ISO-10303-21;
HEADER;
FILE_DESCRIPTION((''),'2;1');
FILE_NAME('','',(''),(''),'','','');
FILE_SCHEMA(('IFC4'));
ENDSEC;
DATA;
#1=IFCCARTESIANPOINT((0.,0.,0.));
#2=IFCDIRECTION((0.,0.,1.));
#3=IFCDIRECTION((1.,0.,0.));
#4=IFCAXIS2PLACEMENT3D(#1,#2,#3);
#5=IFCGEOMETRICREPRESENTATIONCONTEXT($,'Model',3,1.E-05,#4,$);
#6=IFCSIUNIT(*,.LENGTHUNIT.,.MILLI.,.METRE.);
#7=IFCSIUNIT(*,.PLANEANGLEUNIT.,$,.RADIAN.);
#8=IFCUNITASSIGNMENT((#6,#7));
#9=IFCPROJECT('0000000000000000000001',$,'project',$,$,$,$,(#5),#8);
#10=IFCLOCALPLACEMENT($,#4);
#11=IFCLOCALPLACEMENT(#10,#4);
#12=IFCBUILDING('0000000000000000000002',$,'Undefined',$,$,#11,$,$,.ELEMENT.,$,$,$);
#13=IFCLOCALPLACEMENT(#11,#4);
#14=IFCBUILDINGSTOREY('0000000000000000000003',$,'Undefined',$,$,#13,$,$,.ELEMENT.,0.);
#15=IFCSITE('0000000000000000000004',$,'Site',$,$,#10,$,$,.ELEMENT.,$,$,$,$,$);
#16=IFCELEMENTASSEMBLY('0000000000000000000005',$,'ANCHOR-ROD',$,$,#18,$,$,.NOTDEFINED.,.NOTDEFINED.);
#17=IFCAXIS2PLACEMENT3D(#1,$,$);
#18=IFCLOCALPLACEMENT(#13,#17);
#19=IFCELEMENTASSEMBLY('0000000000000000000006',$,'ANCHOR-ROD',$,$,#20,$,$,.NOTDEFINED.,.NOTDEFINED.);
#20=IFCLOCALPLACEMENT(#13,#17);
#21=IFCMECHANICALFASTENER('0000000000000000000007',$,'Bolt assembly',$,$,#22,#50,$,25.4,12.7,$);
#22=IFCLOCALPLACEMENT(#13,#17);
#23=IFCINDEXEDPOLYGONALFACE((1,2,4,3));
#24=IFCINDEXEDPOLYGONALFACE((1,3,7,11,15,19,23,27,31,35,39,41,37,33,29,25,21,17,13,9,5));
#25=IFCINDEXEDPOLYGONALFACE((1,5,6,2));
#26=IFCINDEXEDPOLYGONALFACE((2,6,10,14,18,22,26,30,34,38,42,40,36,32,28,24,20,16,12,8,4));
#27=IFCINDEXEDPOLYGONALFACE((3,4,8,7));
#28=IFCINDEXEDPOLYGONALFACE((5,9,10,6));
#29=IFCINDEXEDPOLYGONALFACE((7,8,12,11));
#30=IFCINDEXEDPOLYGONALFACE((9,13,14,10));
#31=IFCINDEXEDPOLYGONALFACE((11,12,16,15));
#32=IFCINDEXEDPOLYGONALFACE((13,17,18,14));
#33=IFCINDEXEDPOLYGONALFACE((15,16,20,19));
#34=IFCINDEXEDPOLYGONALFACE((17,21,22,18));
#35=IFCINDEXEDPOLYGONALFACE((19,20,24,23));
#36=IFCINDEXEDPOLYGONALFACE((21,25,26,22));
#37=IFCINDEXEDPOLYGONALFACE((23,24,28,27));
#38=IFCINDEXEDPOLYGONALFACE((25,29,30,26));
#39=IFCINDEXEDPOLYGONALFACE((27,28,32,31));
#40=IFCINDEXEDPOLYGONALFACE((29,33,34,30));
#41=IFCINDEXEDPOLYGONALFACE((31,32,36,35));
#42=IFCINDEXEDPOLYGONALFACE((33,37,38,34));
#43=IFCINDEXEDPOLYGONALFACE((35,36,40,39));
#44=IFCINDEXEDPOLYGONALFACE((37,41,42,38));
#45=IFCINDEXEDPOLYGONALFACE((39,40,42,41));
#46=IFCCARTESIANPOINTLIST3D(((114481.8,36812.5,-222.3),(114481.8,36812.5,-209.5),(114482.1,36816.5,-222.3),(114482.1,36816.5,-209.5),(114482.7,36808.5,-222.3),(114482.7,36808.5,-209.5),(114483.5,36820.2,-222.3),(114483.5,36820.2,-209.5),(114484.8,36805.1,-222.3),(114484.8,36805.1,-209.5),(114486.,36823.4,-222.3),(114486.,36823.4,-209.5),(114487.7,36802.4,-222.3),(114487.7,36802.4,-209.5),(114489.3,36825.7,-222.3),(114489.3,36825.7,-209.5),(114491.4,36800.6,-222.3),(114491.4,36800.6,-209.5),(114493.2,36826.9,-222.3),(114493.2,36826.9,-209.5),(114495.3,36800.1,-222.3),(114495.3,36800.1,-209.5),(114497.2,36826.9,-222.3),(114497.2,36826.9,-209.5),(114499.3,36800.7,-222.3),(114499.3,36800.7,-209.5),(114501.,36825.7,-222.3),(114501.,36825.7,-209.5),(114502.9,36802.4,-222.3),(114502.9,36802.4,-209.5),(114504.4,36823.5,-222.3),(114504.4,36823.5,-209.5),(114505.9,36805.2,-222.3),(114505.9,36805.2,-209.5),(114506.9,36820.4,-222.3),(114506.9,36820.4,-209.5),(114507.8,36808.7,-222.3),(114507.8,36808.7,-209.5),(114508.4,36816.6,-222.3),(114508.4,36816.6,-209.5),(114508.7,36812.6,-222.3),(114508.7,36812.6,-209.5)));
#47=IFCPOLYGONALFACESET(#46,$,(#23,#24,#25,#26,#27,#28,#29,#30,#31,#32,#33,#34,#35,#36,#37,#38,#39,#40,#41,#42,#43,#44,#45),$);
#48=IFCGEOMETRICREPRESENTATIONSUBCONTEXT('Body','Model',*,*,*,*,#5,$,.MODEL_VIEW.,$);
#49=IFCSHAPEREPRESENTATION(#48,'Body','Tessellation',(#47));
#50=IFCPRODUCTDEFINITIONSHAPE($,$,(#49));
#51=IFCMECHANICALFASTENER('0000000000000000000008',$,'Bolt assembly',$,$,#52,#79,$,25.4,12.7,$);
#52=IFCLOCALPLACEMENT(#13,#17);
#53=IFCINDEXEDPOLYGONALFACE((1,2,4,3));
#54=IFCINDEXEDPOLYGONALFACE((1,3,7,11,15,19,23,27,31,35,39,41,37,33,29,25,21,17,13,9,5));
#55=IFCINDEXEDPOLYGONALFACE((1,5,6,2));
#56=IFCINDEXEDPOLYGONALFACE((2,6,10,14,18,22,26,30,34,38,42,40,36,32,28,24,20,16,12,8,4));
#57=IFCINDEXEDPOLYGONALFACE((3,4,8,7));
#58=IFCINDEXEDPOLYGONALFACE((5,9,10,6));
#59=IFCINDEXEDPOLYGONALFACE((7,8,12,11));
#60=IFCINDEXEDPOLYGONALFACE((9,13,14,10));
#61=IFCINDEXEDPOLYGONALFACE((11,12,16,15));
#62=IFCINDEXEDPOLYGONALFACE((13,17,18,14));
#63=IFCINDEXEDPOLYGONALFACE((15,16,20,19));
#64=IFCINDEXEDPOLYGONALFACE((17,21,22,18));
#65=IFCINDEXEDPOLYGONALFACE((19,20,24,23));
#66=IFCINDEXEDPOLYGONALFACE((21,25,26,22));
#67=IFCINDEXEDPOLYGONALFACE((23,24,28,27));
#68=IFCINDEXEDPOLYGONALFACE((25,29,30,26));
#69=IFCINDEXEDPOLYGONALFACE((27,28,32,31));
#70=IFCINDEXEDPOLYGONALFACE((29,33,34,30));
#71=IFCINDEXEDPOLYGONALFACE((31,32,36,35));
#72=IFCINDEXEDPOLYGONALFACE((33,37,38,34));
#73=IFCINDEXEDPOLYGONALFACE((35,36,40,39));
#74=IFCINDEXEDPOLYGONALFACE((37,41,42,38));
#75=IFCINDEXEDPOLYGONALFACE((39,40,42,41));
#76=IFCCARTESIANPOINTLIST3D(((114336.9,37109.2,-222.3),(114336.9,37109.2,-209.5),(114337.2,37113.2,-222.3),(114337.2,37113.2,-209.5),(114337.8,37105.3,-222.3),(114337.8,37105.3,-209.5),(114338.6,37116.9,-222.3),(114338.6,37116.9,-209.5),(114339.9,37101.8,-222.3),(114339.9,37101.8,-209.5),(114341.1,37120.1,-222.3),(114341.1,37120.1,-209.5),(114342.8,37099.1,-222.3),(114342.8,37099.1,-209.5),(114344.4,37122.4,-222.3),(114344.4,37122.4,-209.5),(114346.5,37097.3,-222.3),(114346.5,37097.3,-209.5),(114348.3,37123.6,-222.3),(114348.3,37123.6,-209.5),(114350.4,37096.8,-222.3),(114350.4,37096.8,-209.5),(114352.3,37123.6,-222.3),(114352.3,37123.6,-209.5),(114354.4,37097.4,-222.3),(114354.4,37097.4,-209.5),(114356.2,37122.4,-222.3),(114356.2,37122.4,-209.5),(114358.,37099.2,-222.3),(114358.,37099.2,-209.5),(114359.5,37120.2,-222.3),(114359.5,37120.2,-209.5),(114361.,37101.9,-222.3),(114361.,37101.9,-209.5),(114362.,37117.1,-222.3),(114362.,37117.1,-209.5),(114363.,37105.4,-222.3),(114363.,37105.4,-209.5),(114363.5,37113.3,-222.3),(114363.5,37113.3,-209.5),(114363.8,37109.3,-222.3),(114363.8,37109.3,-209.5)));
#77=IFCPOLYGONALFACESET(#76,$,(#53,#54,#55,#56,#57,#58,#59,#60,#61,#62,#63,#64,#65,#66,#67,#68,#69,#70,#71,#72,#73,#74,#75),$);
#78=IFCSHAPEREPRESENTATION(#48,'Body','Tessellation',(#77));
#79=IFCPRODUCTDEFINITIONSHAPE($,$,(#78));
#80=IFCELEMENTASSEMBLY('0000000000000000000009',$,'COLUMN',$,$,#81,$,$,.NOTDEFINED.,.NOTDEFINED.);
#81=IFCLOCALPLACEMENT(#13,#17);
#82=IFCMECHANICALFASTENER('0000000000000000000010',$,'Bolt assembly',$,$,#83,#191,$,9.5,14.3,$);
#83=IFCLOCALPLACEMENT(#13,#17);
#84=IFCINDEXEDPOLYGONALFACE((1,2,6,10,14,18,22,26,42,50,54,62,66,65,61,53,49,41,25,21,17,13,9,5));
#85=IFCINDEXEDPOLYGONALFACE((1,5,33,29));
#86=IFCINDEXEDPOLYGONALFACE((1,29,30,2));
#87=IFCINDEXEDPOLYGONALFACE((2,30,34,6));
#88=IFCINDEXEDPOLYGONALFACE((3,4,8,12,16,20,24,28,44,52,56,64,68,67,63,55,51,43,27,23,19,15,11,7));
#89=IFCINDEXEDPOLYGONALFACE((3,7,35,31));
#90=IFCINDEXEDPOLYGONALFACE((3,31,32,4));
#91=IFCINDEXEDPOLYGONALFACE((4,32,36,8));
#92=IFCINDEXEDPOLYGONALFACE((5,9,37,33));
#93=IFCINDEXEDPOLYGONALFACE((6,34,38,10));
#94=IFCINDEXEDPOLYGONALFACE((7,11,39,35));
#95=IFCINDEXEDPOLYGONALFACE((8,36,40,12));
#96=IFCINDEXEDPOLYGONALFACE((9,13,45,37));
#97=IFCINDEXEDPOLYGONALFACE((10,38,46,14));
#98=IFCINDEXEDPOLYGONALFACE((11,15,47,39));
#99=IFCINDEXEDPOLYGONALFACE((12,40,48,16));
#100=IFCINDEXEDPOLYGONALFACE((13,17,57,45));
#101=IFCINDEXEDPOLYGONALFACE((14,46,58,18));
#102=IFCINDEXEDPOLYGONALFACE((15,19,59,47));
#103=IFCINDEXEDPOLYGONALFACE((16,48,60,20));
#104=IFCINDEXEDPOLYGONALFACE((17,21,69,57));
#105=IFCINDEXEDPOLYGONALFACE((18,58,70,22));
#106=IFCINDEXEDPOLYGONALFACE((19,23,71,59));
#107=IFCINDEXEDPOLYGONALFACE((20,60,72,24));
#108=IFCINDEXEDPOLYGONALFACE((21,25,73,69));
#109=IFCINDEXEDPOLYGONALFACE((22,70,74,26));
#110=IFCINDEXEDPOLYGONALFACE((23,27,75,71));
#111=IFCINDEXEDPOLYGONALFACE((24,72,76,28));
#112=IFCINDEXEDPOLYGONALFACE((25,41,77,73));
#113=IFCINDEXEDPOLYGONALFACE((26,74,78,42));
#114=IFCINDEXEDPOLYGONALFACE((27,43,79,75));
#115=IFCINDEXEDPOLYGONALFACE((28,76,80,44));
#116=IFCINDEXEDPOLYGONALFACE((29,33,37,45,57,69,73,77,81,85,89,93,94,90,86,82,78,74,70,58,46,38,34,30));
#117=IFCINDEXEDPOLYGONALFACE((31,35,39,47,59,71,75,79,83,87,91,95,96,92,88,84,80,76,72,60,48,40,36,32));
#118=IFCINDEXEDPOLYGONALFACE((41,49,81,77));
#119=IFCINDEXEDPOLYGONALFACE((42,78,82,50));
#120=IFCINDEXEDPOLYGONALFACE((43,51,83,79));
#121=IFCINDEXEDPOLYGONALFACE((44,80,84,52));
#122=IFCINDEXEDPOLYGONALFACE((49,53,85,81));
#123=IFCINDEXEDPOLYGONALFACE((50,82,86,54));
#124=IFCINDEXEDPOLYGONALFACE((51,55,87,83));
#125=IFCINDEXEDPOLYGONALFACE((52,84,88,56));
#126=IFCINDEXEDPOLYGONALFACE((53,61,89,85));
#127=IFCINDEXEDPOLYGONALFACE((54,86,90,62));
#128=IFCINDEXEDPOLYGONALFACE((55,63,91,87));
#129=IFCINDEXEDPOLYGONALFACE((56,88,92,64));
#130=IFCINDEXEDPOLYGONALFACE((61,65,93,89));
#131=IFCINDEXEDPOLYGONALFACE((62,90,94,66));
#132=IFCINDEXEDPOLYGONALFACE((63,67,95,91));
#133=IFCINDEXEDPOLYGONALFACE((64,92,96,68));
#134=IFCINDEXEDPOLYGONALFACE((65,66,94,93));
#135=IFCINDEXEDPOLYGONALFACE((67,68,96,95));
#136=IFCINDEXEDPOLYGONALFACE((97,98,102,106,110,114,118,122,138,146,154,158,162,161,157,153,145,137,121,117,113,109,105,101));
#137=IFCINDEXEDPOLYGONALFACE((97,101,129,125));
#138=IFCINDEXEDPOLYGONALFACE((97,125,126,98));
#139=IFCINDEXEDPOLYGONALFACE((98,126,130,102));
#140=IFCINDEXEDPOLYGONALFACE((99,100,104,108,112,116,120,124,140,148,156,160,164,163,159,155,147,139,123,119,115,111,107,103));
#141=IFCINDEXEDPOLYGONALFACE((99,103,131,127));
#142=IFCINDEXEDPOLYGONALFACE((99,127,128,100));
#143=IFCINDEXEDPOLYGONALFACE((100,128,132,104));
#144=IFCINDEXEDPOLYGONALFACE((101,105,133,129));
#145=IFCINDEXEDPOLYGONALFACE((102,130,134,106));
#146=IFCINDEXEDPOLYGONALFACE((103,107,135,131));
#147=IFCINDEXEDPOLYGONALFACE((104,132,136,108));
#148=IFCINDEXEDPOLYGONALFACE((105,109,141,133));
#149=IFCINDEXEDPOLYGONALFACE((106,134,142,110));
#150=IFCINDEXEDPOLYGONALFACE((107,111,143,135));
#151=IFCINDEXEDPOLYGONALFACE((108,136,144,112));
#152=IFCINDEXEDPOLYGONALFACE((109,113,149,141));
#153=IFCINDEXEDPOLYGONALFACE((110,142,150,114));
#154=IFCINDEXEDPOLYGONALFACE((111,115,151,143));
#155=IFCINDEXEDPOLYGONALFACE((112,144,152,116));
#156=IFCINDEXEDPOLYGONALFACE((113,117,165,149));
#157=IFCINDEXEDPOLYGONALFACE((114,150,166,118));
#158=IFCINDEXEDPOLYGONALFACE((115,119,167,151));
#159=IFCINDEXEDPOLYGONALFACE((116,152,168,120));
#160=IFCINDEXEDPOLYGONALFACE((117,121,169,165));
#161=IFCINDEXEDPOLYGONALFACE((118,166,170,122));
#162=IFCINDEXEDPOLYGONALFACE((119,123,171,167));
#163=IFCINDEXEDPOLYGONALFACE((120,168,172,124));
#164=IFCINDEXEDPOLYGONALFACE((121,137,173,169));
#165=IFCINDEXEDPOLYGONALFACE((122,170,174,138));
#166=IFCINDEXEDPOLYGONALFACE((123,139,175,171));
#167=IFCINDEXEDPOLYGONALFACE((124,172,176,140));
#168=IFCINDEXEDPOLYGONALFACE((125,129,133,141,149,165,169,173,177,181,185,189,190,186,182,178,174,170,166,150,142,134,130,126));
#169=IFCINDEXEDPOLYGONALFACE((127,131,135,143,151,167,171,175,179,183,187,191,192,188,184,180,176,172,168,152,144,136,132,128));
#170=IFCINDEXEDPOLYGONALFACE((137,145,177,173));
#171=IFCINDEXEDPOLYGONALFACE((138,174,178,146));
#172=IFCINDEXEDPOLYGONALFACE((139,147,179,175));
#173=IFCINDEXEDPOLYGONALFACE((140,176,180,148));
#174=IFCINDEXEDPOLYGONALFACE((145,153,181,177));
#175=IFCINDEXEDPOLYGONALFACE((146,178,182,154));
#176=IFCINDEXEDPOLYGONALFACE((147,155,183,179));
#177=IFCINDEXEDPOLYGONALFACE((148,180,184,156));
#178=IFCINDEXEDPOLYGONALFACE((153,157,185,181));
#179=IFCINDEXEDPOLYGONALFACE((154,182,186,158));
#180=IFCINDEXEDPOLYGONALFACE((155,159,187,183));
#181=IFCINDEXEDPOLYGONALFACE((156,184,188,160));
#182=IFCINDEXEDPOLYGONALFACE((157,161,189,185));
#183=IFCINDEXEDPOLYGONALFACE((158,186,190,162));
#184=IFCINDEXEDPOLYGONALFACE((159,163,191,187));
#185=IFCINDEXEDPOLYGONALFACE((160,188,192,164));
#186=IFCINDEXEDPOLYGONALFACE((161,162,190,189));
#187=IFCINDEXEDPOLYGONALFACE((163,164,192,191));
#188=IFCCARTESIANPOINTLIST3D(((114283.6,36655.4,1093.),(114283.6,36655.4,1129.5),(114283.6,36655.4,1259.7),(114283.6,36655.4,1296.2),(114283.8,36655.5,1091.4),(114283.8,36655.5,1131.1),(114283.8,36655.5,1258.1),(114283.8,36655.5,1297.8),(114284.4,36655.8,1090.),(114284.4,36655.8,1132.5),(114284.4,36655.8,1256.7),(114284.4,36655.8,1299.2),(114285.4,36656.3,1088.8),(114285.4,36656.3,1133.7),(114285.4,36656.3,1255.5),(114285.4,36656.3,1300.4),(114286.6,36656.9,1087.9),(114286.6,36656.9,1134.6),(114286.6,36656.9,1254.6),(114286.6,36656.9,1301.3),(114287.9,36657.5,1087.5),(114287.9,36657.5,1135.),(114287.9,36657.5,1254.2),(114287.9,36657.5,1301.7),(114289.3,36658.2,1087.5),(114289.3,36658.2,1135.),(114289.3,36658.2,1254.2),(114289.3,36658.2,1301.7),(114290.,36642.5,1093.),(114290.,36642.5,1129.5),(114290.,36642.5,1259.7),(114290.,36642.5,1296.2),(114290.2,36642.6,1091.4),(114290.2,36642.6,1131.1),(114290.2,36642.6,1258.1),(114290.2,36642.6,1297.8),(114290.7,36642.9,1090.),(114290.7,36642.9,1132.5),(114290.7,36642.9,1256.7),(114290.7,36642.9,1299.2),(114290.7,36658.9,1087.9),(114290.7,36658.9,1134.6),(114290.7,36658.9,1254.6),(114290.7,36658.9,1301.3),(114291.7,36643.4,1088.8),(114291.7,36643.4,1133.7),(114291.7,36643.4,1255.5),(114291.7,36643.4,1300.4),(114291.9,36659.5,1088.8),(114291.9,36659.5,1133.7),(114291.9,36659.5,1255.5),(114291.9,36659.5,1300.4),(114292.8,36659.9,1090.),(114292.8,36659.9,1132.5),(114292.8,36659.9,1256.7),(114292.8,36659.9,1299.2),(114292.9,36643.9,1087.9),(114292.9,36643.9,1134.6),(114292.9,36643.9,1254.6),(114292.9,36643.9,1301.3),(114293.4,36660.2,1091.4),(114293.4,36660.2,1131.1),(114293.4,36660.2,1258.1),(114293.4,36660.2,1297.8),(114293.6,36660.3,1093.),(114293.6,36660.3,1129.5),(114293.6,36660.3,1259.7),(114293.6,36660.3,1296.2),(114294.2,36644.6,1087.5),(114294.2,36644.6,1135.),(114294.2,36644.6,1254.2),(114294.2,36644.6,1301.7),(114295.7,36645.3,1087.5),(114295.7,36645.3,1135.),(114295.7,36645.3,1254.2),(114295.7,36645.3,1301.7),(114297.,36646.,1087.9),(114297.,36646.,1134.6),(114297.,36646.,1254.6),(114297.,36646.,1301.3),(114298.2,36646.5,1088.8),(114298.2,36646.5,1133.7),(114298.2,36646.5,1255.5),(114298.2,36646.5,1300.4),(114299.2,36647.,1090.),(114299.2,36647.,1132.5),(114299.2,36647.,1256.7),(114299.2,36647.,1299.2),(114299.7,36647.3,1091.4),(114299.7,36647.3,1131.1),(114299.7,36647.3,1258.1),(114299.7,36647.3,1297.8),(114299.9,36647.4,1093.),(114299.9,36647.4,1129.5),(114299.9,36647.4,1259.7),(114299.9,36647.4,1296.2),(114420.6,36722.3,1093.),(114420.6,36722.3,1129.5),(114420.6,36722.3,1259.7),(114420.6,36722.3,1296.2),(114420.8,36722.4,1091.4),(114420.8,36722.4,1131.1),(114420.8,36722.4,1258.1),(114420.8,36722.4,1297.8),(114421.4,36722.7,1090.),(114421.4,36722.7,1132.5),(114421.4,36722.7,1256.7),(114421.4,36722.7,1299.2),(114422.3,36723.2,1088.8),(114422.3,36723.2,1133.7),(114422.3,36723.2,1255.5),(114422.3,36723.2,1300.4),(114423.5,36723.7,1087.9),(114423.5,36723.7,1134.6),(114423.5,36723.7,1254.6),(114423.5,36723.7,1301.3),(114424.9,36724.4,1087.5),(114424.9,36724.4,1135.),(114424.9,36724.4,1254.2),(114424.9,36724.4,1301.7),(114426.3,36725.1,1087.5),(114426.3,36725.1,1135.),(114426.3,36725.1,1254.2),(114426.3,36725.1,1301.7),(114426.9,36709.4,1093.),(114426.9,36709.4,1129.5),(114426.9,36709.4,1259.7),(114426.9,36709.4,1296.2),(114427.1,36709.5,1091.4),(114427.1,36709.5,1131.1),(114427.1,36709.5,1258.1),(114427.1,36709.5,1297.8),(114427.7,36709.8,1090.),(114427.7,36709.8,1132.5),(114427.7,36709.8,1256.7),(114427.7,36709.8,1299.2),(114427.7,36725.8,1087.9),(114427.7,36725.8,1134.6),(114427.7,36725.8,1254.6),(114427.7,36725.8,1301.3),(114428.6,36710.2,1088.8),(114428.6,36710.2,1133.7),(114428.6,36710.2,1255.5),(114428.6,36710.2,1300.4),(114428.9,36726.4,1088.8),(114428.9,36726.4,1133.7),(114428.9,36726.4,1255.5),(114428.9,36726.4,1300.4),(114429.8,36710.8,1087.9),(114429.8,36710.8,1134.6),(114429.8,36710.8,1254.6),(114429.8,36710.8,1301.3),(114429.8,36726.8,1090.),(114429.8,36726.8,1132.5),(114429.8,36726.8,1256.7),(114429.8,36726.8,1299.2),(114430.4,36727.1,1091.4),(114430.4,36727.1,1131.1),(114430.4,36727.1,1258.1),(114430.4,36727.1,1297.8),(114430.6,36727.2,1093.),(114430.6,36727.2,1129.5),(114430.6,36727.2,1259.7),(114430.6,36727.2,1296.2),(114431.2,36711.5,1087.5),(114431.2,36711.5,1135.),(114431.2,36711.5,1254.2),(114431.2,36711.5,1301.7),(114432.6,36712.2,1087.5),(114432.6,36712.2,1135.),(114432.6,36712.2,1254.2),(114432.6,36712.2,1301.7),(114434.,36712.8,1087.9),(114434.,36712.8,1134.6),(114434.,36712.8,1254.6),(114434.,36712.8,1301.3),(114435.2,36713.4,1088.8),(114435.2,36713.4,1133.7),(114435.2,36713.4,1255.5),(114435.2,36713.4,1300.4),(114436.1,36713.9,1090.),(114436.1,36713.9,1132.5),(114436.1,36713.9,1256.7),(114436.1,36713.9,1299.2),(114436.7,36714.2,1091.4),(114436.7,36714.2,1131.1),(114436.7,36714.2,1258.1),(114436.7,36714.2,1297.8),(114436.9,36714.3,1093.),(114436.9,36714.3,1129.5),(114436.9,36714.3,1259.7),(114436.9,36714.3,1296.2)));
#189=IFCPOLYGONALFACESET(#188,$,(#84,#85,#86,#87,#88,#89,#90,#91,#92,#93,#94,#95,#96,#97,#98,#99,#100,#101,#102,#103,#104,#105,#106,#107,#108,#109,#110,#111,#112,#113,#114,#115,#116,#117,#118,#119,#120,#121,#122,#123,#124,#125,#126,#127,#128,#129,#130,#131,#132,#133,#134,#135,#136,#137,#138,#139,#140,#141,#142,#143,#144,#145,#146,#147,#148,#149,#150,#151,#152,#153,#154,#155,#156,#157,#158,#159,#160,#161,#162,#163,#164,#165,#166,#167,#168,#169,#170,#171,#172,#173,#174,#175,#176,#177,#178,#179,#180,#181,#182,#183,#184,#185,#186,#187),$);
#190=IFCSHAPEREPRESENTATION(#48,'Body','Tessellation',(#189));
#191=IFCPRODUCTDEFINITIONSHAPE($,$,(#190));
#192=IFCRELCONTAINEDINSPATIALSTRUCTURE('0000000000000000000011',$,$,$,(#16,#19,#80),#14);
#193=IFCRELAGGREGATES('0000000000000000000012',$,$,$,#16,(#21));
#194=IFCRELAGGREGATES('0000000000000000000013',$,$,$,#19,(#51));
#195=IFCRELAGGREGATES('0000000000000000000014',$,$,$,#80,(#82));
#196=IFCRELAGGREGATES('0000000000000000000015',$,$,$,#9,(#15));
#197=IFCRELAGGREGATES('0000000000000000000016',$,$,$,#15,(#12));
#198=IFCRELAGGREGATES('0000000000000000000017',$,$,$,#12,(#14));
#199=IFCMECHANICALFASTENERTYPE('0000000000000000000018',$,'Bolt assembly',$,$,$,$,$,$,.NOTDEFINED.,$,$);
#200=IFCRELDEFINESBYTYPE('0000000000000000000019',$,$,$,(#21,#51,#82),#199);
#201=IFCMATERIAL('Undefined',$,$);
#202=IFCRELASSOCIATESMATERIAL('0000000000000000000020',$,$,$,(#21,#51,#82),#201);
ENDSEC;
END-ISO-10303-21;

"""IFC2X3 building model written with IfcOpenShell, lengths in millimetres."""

from ifc_helpers import new_model, si_unit, frame, frame_2d, origin_with_axes, origin_2d_with_axis, place, context, subcontext, project, spatial, polyline, circle_curve, parameter, trimmed, segment, composite_curve, circle, outline, extrude, source, transform, mapped, material, type_object, element, aggregate, save


model = new_model("IFC2X3")

# Units and contexts
model_context = context("Model", 3, precision=1e-05, world=origin_with_axes())
body_context = subcontext(model_context, "Body", "Model", "MODEL_VIEW")
ifc_project = project(units=[si_unit("LENGTHUNIT", "METRE", prefix="MILLI"), si_unit("PLANEANGLEUNIT", "RADIAN")], contexts=[model_context])

# Site, building, storey
site_placement = place(None, origin_with_axes())
site = spatial("IfcSite", under=ifc_project, at=site_placement, Name="Site", CompositionType="ELEMENT")
building_placement = place(site_placement, origin_with_axes())
building = spatial("IfcBuilding", under=site, at=building_placement, Name="Undefined", CompositionType="ELEMENT")
storey_placement = place(building_placement, origin_with_axes())
storey = spatial("IfcBuildingStorey", under=building, at=storey_placement, Name="Undefined", CompositionType="ELEMENT", Elevation=0.0)

# Element assemblies
assembly_1_placement = place(storey_placement, origin_with_axes())
assembly_1 = element("IfcElementAssembly", 1, at=assembly_1_placement, inside=storey, Name="ANCHOR-ROD", AssemblyPlace="NOTDEFINED", PredefinedType="NOTDEFINED")
assembly_2_placement = place(storey_placement, origin_with_axes())
assembly_2 = element("IfcElementAssembly", 2, at=assembly_2_placement, inside=storey, Name="ANCHOR-ROD", AssemblyPlace="NOTDEFINED", PredefinedType="NOTDEFINED")

# Mechanical fasteners
ifc_material_1 = material(Name="Undefined")
mechanical_fastener_type = type_object("IfcMechanicalFastenerType", Name="Bolt assembly")
shared_shape_1 = source(origin_with_axes(), body_context, "Body", "SweptSolid", [
    extrude(circle(Radius=13.5, at=origin_2d_with_axis()), frame((0.0, 0.0, 0.0), z_axis=(0.0, 1.0, 0.0), x_axis=(1.0, 0.0, 0.0)), (0.0, 0.0, 1.0), 12.8),
])
mechanical_fastener_1_placement = place(assembly_1_placement, frame((114495.3, 36813.5, -222.3), z_axis=(0.898581, 0.438807, 0.0), x_axis=(-0.438807, 0.898581, 0.0)))
mechanical_fastener_1 = element("IfcMechanicalFastener", 3, at=mechanical_fastener_1_placement, type_object=mechanical_fastener_type, material=ifc_material_1, Name="Bolt assembly", NominalDiameter=25.4, NominalLength=12.7, context=body_context, shape_type="MappedRepresentation", body=[
    mapped(shared_shape_1, transform((0.0, 0.0, 0.0))),
])
aggregate(assembly_1, [mechanical_fastener_1])
mechanical_fastener_2_placement = place(assembly_2_placement, frame((114350.4, 37110.3, -222.3), z_axis=(0.898581, 0.438807, 0.0), x_axis=(-0.438807, 0.898581, 0.0)))
mechanical_fastener_2 = element("IfcMechanicalFastener", 4, at=mechanical_fastener_2_placement, type_object=mechanical_fastener_type, material=ifc_material_1, Name="Bolt assembly", NominalDiameter=25.4, NominalLength=12.7, context=body_context, shape_type="MappedRepresentation", body=[
    mapped(shared_shape_1, transform((0.0, 0.0, 0.0))),
])
aggregate(assembly_2, [mechanical_fastener_2])

# Element assembly, mechanical fastener
assembly_3_placement = place(storey_placement, origin_with_axes())
assembly_3 = element("IfcElementAssembly", 5, at=assembly_3_placement, inside=storey, Name="COLUMN", AssemblyPlace="NOTDEFINED", PredefinedType="NOTDEFINED")
shared_shape_2 = source(origin_with_axes(), body_context, "Body", "SweptSolid", [
    extrude(outline(composite_curve([segment(polyline([(-18.3, 5.6), (18.3, 5.6)]), True, "CONTINUOUS"), segment(trimmed(circle_curve(frame_2d((18.3, 0.0), x_axis=(0.0, 1.0)), 5.6), [parameter(0.0)], [parameter(3.141593)], False, "PARAMETER"), True, "CONTINUOUS"), segment(polyline([(18.3, -5.6), (-18.3, -5.6)]), True, "CONTINUOUS"), segment(trimmed(circle_curve(frame_2d((-18.3, 0.0), x_axis=(0.0, -1.0)), 5.6), [parameter(0.0)], [parameter(3.141593)], False, "PARAMETER"), True, "DISCONTINUOUS")], self_intersect=False)), frame((0.0, -12.7, 0.0), z_axis=(0.0, 1.0, 0.0), x_axis=(1.0, 0.0, 0.0)), (0.0, 0.0, 1.0), 14.4),
])
mechanical_fastener_3_placement = place(assembly_3_placement, frame((114362.7, 36679.9, 1111.3), z_axis=(0.898581, 0.438807, 0.0), x_axis=(0.0, 0.0, 1.0)))
mechanical_fastener_3 = element("IfcMechanicalFastener", 6, at=mechanical_fastener_3_placement, type_object=mechanical_fastener_type, material=ifc_material_1, Name="Bolt assembly", NominalDiameter=9.5, NominalLength=14.3, context=body_context, shape_type="MappedRepresentation", body=[
    mapped(shared_shape_2, transform((0.0, 0.0, 76.2))),
    mapped(shared_shape_2, transform((166.7, 0.0, 76.2))),
    mapped(shared_shape_2, transform((0.0, 0.0, -76.2))),
    mapped(shared_shape_2, transform((166.7, 0.0, -76.2))),
])
aggregate(assembly_3, [mechanical_fastener_3])

save(model, "model.ifc")
